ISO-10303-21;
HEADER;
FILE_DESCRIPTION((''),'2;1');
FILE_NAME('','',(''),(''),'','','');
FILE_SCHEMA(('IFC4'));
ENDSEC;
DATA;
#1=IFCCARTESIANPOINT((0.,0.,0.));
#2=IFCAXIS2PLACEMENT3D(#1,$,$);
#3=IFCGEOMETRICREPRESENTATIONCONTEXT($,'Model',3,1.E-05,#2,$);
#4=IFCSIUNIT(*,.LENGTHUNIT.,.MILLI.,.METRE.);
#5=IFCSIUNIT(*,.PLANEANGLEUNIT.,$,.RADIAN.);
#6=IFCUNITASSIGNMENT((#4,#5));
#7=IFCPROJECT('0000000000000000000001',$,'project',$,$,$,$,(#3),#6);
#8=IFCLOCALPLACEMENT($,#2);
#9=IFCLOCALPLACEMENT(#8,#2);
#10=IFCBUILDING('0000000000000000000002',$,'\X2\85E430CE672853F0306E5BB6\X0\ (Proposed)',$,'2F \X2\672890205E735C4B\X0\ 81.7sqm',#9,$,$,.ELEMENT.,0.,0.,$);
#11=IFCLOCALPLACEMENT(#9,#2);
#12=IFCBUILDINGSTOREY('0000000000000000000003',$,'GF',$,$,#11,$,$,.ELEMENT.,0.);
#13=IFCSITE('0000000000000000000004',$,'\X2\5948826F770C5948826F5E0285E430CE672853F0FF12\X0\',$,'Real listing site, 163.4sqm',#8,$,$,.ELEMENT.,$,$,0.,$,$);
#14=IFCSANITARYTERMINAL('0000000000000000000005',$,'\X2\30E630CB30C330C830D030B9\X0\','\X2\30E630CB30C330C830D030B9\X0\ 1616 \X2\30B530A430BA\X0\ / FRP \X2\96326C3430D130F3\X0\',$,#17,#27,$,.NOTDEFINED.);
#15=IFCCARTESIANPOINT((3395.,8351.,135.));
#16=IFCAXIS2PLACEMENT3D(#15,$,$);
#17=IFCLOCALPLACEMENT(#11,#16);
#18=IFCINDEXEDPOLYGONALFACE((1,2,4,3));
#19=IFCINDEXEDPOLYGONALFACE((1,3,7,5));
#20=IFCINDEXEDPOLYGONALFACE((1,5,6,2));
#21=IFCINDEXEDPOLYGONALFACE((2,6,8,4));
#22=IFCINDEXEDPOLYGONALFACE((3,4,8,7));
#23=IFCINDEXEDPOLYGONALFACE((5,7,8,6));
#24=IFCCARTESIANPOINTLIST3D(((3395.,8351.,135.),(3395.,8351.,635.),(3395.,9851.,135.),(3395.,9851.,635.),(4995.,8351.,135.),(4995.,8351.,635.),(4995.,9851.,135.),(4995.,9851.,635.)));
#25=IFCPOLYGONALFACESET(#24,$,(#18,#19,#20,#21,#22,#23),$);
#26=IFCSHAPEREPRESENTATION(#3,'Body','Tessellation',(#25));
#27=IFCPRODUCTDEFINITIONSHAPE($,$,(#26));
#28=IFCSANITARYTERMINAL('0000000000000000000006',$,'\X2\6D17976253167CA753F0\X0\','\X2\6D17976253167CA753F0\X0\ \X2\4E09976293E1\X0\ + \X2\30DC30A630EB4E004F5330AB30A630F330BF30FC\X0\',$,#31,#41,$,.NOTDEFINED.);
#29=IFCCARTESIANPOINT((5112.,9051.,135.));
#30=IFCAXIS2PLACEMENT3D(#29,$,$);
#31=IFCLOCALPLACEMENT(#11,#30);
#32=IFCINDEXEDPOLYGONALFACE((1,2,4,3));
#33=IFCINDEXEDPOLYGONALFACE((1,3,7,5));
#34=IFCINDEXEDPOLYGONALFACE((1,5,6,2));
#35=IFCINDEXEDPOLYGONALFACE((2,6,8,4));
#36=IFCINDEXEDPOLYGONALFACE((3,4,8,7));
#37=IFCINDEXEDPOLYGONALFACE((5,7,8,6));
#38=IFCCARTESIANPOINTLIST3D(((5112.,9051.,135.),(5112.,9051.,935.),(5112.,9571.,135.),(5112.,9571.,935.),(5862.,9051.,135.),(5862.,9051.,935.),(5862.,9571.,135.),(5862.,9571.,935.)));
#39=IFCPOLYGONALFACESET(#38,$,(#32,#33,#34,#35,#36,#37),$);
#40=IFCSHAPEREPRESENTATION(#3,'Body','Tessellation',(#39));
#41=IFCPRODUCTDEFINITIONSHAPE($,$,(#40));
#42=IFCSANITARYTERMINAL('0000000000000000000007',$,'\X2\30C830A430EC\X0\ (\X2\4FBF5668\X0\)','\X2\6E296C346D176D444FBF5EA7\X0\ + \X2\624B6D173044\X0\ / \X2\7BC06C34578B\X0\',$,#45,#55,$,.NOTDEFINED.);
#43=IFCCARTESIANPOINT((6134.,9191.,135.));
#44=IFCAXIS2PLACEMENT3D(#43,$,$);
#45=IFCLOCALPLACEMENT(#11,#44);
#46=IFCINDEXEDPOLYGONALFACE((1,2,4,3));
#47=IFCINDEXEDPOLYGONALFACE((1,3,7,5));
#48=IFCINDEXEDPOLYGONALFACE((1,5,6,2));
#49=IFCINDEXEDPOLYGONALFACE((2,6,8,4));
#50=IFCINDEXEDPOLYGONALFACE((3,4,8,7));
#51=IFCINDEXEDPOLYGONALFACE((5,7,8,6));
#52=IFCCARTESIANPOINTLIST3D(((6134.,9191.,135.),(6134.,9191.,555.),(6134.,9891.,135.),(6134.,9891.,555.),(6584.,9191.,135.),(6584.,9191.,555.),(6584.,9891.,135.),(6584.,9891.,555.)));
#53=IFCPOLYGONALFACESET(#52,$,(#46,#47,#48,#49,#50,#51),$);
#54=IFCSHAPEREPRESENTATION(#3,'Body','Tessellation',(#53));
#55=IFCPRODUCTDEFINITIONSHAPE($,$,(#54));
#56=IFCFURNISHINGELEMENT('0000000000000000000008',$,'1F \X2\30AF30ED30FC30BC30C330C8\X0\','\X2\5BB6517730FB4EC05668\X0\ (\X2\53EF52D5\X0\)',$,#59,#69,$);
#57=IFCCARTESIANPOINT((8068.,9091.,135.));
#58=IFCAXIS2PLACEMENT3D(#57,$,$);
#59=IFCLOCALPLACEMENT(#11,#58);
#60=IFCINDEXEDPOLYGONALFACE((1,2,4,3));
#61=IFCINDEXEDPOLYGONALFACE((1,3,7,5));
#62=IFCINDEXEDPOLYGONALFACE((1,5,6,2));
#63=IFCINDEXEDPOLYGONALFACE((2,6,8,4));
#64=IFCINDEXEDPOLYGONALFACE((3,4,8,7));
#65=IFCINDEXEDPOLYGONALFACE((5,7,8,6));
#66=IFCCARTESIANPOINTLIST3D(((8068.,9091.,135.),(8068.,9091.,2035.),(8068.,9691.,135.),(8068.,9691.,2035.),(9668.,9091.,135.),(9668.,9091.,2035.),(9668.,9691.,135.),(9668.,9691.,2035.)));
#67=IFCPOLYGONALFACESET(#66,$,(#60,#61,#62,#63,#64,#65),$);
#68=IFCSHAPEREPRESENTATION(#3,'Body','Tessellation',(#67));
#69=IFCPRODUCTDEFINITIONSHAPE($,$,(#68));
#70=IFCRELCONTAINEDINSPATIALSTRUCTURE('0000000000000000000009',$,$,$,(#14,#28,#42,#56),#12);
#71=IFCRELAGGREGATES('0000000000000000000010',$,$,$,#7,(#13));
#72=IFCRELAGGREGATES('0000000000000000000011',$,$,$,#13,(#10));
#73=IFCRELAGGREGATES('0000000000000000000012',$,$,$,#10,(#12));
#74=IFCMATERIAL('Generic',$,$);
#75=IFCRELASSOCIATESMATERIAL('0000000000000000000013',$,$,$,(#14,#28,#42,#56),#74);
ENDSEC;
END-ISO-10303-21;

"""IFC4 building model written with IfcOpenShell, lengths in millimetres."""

from ifc_helpers import new_model, si_unit, frame, frame_2d, origin, place, context, project, spatial, rectangle, extrude, material, element, save


model = new_model("IFC4")

# Units and contexts
model_context = context("Model", 3, precision=1e-05, world=origin())
ifc_project = project(units=[si_unit("LENGTHUNIT", "METRE", prefix="MILLI"), si_unit("PLANEANGLEUNIT", "RADIAN")], contexts=[model_context])

# Site, building, storey
site_placement = place(None, origin())
site = spatial("IfcSite", under=ifc_project, at=site_placement, Name="奈良県奈良市藤ノ木台２", ObjectType="Real listing site, 163.4sqm", CompositionType="ELEMENT", RefElevation=0.0)
building_placement = place(site_placement, origin())
building = spatial("IfcBuilding", under=site, at=building_placement, Name="藤ノ木台の家 (Proposed)", ObjectType="2F 木造平屋 81.7sqm", CompositionType="ELEMENT", ElevationOfRefHeight=0.0, ElevationOfTerrain=0.0)
storey_placement = place(building_placement, origin())
storey = spatial("IfcBuildingStorey", under=building, at=storey_placement, Name="GF", CompositionType="ELEMENT", Elevation=0.0)

# Shared definitions
ifc_material_1 = material(Name="Generic")

# Sanitary terminals
sanitary_terminal_1_placement = place(storey_placement, frame((3395.0, 8351.0, 135.0)))
element("IfcSanitaryTerminal", 1, at=sanitary_terminal_1_placement, inside=storey, material=ifc_material_1, Name="ユニットバス", Description="ユニットバス 1616 サイズ / FRP 防水パン", PredefinedType="NOTDEFINED", context=model_context, shape_type="SweptSolid", body=[
    extrude(rectangle(XDim=1600.0, YDim=1500.0, at=frame_2d((800.0, 750.0))), frame((3395.0, 8351.0, 135.0)), (0.0, 0.0, 1.0), 500.0),
])
sanitary_terminal_2_placement = place(storey_placement, frame((5112.0, 9051.0, 135.0)))
element("IfcSanitaryTerminal", 2, at=sanitary_terminal_2_placement, inside=storey, material=ifc_material_1, Name="洗面化粧台", Description="洗面化粧台 三面鏡 + ボウル一体カウンター", PredefinedType="NOTDEFINED", context=model_context, shape_type="SweptSolid", body=[
    extrude(rectangle(XDim=750.0, YDim=520.0, at=frame_2d((375.0, 260.0))), frame((5112.0, 9051.0, 135.0)), (0.0, 0.0, 1.0), 800.0),
])
sanitary_terminal_3_placement = place(storey_placement, frame((6134.0, 9191.0, 135.0)))
element("IfcSanitaryTerminal", 3, at=sanitary_terminal_3_placement, inside=storey, material=ifc_material_1, Name="トイレ (便器)", Description="温水洗浄便座 + 手洗い / 節水型", PredefinedType="NOTDEFINED", context=model_context, shape_type="SweptSolid", body=[
    extrude(rectangle(XDim=450.0, YDim=700.0, at=frame_2d((225.0, 350.0))), frame((6134.0, 9191.0, 135.0)), (0.0, 0.0, 1.0), 420.0),
])

# Furnishing element
furnishing_placement = place(storey_placement, frame((8068.0, 9091.0, 135.0)))
element("IfcFurnishingElement", 4, at=furnishing_placement, inside=storey, material=ifc_material_1, Name="1F クローゼット", Description="家具・什器 (可動)", context=model_context, shape_type="SweptSolid", body=[
    extrude(rectangle(XDim=1600.0, YDim=600.0, at=frame_2d((800.0, 300.0))), frame((8068.0, 9091.0, 135.0)), (0.0, 0.0, 1.0), 1900.0),
])

save(model, "model.ifc")
